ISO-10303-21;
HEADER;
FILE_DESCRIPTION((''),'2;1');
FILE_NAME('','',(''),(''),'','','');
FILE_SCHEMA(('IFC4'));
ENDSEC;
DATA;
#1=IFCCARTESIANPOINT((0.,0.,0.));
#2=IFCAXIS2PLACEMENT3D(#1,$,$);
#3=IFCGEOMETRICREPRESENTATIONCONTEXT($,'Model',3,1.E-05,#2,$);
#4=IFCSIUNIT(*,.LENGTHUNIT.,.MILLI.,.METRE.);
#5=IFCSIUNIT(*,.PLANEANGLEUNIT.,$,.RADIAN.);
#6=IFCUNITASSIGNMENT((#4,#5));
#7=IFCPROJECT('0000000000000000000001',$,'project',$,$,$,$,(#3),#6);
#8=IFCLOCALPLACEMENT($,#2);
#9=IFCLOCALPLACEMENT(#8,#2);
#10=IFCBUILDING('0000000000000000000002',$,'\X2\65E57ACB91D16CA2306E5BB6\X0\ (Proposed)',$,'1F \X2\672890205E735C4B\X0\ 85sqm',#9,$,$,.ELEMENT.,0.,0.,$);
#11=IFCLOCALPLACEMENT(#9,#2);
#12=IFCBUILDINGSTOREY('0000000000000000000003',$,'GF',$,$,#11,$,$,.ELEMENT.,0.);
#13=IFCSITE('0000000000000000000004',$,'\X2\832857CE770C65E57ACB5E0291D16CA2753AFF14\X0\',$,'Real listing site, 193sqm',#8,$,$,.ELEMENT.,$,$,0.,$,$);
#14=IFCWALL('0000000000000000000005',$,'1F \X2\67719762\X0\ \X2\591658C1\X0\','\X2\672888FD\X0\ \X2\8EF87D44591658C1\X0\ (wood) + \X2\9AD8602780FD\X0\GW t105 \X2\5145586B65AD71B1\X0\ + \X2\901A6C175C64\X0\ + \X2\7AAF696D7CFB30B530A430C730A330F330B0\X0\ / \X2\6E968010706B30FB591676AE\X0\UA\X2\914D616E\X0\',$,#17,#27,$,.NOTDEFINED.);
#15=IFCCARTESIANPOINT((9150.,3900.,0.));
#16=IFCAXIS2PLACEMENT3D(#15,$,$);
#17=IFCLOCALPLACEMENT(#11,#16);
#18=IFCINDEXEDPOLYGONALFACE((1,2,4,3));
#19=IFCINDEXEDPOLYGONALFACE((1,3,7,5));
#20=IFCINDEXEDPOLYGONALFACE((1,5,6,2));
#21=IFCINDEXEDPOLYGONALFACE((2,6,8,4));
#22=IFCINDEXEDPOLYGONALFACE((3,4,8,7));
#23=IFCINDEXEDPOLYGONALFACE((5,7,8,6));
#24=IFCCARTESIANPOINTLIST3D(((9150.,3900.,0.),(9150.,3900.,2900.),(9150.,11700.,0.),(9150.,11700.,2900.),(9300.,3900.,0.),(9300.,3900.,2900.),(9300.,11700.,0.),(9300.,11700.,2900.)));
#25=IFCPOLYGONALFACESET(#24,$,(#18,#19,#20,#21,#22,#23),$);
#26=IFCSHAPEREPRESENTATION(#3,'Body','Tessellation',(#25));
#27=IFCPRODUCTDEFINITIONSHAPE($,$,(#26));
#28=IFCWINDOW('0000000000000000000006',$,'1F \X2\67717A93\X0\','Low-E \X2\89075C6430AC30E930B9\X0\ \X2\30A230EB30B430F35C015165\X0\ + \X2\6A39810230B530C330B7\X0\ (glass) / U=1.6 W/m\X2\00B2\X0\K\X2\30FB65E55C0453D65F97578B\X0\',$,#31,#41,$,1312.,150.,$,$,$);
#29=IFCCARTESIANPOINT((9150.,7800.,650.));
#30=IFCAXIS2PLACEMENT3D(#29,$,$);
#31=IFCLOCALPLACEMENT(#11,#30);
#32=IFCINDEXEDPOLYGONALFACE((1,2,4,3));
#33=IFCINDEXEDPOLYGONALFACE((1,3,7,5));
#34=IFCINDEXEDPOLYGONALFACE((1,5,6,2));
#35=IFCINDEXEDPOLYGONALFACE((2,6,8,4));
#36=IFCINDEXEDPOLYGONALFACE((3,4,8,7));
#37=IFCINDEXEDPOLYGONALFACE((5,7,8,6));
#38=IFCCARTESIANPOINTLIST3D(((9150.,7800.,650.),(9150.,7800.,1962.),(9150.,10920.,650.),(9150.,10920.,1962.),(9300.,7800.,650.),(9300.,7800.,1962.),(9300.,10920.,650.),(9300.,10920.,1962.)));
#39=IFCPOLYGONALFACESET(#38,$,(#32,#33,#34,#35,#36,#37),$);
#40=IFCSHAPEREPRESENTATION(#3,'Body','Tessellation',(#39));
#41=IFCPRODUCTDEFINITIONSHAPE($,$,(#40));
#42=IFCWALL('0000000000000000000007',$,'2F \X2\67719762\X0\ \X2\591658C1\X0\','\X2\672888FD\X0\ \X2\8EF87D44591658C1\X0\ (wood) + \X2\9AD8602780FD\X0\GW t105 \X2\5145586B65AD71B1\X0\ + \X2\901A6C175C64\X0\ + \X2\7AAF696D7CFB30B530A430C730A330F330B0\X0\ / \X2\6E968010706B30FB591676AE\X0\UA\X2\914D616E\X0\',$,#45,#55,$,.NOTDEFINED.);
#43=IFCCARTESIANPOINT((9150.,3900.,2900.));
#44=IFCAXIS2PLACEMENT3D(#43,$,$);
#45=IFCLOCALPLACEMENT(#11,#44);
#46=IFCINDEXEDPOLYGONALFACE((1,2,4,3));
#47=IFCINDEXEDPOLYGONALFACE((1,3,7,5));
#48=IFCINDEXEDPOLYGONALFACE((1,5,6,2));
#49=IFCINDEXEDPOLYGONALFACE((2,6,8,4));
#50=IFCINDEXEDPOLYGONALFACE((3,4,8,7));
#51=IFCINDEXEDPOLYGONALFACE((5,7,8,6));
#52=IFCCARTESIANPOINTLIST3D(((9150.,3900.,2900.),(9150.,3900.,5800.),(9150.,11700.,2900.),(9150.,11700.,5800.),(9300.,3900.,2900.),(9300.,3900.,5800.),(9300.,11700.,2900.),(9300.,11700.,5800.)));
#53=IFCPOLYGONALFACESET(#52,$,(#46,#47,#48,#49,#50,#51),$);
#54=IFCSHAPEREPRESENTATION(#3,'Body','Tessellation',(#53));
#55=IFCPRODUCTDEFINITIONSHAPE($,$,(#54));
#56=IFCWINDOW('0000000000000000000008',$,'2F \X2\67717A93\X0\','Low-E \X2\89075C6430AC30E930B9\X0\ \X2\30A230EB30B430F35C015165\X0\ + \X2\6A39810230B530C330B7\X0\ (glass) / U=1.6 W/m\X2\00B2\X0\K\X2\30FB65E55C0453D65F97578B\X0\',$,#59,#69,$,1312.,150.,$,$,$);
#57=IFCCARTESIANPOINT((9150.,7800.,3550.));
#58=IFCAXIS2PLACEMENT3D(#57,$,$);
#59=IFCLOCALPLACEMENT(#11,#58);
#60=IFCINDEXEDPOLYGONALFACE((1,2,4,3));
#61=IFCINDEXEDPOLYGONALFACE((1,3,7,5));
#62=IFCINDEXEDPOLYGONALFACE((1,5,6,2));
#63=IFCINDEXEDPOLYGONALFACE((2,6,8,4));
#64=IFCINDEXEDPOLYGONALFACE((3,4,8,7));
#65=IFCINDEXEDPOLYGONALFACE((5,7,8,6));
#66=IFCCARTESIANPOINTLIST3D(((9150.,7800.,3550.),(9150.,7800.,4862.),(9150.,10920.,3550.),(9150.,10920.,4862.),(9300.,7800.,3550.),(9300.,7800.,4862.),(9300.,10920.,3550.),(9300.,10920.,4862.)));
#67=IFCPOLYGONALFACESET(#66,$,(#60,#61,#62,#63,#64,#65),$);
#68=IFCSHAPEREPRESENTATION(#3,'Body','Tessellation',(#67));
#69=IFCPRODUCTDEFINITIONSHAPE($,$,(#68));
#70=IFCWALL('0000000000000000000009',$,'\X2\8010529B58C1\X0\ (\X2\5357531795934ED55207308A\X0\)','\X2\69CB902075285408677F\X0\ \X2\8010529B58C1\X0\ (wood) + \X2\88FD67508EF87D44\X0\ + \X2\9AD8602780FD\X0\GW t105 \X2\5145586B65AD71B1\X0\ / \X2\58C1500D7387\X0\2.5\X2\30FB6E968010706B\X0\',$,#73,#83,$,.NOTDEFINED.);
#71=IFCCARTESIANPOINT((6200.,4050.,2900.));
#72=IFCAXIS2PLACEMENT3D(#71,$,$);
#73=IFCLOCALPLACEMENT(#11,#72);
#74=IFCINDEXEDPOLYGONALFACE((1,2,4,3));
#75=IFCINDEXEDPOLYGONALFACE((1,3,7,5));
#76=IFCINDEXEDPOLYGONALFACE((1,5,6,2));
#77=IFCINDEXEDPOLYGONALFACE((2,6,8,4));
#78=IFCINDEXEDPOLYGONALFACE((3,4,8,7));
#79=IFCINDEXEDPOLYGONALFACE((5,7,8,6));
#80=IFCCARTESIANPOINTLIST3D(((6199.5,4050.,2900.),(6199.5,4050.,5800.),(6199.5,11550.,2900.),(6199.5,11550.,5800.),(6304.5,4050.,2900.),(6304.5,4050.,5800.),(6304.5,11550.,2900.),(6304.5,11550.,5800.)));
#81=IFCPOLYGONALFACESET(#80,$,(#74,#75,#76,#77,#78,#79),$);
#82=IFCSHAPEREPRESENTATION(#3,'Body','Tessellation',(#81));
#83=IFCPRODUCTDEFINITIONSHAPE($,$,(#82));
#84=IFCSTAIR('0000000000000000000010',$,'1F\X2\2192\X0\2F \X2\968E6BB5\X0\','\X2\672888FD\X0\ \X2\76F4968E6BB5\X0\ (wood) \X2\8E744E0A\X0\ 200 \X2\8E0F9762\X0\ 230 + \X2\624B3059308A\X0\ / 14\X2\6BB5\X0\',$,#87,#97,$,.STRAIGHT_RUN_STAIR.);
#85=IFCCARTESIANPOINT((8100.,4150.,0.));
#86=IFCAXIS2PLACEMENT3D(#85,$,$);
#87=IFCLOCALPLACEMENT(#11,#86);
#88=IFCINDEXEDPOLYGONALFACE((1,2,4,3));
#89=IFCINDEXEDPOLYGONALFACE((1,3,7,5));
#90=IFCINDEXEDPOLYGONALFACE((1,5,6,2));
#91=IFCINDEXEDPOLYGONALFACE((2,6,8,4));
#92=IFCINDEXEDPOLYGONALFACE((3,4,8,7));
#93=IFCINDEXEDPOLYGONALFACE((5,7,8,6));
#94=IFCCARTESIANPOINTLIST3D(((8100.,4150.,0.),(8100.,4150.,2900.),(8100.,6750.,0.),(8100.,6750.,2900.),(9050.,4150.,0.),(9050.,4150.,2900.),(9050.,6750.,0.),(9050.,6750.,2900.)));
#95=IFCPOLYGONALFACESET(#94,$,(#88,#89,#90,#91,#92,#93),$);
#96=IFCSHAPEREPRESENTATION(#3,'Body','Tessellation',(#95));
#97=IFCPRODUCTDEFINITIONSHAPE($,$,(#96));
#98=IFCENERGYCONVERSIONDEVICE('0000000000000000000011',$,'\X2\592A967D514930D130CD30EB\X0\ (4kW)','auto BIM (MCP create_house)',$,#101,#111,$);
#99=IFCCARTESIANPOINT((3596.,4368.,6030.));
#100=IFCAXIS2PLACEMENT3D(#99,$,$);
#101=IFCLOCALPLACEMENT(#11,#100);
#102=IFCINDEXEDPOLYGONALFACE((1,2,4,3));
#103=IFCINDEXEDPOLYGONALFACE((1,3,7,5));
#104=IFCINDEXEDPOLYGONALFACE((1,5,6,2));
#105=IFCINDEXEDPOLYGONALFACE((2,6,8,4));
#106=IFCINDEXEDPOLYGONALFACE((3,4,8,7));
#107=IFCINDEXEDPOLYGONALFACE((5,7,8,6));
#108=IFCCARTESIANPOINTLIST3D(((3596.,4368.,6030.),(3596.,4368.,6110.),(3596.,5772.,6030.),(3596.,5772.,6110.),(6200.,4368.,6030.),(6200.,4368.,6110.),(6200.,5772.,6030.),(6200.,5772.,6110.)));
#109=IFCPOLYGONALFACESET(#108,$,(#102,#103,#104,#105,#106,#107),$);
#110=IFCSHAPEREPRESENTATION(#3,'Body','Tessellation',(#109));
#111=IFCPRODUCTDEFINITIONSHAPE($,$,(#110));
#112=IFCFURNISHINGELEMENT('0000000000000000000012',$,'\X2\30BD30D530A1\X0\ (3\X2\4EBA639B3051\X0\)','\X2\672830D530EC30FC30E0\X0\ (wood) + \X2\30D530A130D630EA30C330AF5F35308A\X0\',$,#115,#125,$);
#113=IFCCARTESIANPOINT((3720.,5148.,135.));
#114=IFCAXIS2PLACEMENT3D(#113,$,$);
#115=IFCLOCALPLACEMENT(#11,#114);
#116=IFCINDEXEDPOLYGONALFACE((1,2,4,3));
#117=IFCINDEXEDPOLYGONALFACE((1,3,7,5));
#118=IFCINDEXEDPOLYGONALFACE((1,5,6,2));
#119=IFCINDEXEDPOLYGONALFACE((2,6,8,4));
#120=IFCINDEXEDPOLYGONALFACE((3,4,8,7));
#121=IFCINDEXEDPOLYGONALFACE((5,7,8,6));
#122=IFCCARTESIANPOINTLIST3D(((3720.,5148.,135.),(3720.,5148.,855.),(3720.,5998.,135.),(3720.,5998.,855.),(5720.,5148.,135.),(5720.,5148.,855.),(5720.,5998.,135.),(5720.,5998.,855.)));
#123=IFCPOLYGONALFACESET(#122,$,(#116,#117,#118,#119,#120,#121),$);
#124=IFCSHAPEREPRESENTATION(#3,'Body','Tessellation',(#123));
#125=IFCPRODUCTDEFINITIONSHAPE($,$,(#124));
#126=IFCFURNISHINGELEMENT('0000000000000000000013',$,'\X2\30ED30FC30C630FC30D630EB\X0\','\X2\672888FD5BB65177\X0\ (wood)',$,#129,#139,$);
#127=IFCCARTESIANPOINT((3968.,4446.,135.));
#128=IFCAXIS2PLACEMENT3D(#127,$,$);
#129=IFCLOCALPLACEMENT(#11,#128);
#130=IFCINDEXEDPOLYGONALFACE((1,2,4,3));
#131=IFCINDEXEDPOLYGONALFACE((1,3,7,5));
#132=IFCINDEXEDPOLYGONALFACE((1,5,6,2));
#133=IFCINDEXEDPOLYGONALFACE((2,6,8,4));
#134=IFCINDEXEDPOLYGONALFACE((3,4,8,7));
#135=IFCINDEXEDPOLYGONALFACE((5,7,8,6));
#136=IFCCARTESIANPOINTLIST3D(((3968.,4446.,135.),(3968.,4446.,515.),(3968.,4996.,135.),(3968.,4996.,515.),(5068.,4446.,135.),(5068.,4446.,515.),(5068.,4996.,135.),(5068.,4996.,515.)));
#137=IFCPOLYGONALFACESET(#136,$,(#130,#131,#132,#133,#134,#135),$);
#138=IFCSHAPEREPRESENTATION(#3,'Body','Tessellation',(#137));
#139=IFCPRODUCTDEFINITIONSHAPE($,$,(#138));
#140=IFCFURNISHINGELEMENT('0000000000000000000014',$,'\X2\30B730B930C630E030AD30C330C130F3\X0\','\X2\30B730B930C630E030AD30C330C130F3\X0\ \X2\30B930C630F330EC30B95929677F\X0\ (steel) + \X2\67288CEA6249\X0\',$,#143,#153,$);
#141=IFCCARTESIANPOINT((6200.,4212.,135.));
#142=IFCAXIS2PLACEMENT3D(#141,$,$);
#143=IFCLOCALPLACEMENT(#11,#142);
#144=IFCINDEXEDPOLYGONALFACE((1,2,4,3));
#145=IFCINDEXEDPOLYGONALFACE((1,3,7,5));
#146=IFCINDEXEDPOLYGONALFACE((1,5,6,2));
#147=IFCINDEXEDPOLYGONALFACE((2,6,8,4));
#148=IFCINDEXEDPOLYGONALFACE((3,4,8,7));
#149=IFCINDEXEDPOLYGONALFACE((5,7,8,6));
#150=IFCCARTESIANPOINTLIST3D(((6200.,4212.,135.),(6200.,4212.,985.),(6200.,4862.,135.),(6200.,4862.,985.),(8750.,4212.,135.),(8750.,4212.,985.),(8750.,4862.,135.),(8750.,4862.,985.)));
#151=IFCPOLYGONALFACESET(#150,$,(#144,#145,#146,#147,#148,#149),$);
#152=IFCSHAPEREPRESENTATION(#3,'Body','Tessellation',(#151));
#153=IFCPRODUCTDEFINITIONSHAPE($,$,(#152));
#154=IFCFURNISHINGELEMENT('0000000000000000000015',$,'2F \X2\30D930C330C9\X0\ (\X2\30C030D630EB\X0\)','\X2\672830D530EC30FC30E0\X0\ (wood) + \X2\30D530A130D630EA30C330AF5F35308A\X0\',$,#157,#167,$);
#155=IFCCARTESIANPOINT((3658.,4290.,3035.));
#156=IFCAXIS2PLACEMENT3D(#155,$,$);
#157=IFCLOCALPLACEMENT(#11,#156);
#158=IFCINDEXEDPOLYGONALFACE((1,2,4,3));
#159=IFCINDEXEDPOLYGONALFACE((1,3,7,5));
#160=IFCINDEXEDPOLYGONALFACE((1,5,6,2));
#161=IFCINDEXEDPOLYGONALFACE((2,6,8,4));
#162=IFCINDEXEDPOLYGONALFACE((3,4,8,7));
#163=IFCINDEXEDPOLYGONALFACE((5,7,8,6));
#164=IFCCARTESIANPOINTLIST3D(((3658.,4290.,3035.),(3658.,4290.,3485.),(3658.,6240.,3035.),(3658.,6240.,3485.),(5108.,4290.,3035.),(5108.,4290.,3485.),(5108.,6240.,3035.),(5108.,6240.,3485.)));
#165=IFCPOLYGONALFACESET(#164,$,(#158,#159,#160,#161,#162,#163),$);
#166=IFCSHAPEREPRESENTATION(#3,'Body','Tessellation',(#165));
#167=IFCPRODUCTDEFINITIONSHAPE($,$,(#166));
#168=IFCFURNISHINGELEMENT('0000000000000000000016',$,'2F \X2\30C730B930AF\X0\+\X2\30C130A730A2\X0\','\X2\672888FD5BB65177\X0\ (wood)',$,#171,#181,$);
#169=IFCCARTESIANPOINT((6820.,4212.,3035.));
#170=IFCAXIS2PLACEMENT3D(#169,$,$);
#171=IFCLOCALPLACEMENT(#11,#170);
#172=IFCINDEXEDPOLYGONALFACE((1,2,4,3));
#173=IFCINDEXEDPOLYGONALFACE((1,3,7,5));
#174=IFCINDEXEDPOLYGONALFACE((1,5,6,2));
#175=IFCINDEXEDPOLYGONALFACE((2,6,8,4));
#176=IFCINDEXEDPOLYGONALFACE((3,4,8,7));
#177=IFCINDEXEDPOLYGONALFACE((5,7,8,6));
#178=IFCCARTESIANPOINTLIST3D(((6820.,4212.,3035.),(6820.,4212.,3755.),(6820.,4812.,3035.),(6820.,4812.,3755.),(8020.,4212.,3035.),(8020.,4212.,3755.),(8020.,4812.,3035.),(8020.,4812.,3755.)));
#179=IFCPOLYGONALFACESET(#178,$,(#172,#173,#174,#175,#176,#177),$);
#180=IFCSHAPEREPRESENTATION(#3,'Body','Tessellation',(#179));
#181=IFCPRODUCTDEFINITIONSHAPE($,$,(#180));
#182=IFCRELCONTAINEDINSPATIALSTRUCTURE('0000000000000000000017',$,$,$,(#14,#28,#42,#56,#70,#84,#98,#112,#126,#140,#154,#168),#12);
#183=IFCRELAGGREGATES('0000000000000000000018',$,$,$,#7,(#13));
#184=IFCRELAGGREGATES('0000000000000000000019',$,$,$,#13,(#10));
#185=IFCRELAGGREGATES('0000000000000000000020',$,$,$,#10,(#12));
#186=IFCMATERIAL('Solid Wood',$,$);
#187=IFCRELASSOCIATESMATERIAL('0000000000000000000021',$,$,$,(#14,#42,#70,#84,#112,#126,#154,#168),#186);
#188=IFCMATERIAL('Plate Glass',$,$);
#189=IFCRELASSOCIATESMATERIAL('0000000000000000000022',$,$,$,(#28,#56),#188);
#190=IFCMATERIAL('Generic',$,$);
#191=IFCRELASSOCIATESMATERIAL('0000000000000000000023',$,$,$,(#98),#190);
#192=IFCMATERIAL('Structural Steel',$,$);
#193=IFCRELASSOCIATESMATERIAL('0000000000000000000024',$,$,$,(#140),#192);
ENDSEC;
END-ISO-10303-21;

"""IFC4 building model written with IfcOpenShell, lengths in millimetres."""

from ifc_helpers import new_model, si_unit, frame, frame_2d, origin, place, context, project, spatial, rectangle, extrude, material, element, fill, save


model = new_model("IFC4")

# Units and contexts
model_context = context("Model", 3, precision=1e-05, world=origin())
ifc_project = project(units=[si_unit("LENGTHUNIT", "METRE", prefix="MILLI"), si_unit("PLANEANGLEUNIT", "RADIAN")], contexts=[model_context])

# Site, building, storey
site_placement = place(None, origin())
site = spatial("IfcSite", under=ifc_project, at=site_placement, Name="茨城県日立市金沢町４", ObjectType="Real listing site, 193sqm", CompositionType="ELEMENT", RefElevation=0.0)
building_placement = place(site_placement, origin())
building = spatial("IfcBuilding", under=site, at=building_placement, Name="日立金沢の家 (Proposed)", ObjectType="1F 木造平屋 85sqm", CompositionType="ELEMENT", ElevationOfRefHeight=0.0, ElevationOfTerrain=0.0)
storey_placement = place(building_placement, origin())
storey = spatial("IfcBuildingStorey", under=building, at=storey_placement, Name="GF", CompositionType="ELEMENT", Elevation=0.0)

# Wall, opening, window
ifc_material_1 = material(Name="Solid Wood")
wall_1_placement = place(storey_placement, frame((9150.0, 3900.0, 0.0)))
wall_1 = element("IfcWall", 1, at=wall_1_placement, inside=storey, material=ifc_material_1, Name="1F 東面 外壁", Description="木製 軸組外壁 (wood) + 高性能GW t105 充填断熱 + 通気層 + 窯業系サイディング / 準耐火・外皮UA配慮", PredefinedType="NOTDEFINED", context=model_context, shape_type="SweptSolid", body=[
    extrude(rectangle(XDim=150.0, YDim=7800.0, at=frame_2d((75.0, 3900.0))), frame((9150.0, 3900.0, 0.0)), (0.0, 0.0, 1.0), 2900.0),
])
opening_1_placement = place(storey_placement, frame((9150.0, 7800.0, 650.0)))
opening_1 = element("IfcOpeningElement", 2, at=opening_1_placement, cuts=wall_1, PredefinedType="NOTDEFINED", context=model_context, shape_type="SweptSolid", body=[
    extrude(rectangle(XDim=150.0, YDim=3120.0, at=frame_2d((75.0, 1560.0))), frame((9150.0, 7800.0, 650.0)), (0.0, 0.0, 1.0), 1312.0),
])
ifc_material_2 = material(Name="Plate Glass")
window_1_placement = place(storey_placement, frame((9150.0, 7800.0, 650.0)))
window_1 = element("IfcWindow", 3, at=window_1_placement, inside=storey, material=ifc_material_2, Name="1F 東窓", Description="Low-E 複層ガラス アルゴン封入 + 樹脂サッシ (glass) / U=1.6 W/m²K・日射取得型", OverallHeight=1312.0, OverallWidth=150.0, context=model_context, shape_type="SweptSolid", body=[
    extrude(rectangle(XDim=150.0, YDim=3120.0, at=frame_2d((75.0, 1560.0))), frame((9150.0, 7800.0, 650.0)), (0.0, 0.0, 1.0), 1312.0),
])
fill(opening_1, window_1)

# Wall, opening, window
wall_2_placement = place(storey_placement, frame((9150.0, 3900.0, 2900.0)))
wall_2 = element("IfcWall", 4, at=wall_2_placement, inside=storey, material=ifc_material_1, Name="2F 東面 外壁", Description="木製 軸組外壁 (wood) + 高性能GW t105 充填断熱 + 通気層 + 窯業系サイディング / 準耐火・外皮UA配慮", PredefinedType="NOTDEFINED", context=model_context, shape_type="SweptSolid", body=[
    extrude(rectangle(XDim=150.0, YDim=7800.0, at=frame_2d((75.0, 3900.0))), frame((9150.0, 3900.0, 2900.0)), (0.0, 0.0, 1.0), 2900.0),
])
opening_2_placement = place(storey_placement, frame((9150.0, 7800.0, 3550.0)))
opening_2 = element("IfcOpeningElement", 5, at=opening_2_placement, cuts=wall_2, PredefinedType="NOTDEFINED", context=model_context, shape_type="SweptSolid", body=[
    extrude(rectangle(XDim=150.0, YDim=3120.0, at=frame_2d((75.0, 1560.0))), frame((9150.0, 7800.0, 3550.0)), (0.0, 0.0, 1.0), 1312.0),
])
window_2_placement = place(storey_placement, frame((9150.0, 7800.0, 3550.0)))
window_2 = element("IfcWindow", 6, at=window_2_placement, inside=storey, material=ifc_material_2, Name="2F 東窓", Description="Low-E 複層ガラス アルゴン封入 + 樹脂サッシ (glass) / U=1.6 W/m²K・日射取得型", OverallHeight=1312.0, OverallWidth=150.0, context=model_context, shape_type="SweptSolid", body=[
    extrude(rectangle(XDim=150.0, YDim=3120.0, at=frame_2d((75.0, 1560.0))), frame((9150.0, 7800.0, 3550.0)), (0.0, 0.0, 1.0), 1312.0),
])
fill(opening_2, window_2)

# Wall
wall_3_placement = place(storey_placement, frame((6200.0, 4050.0, 2900.0)))
element("IfcWall", 7, at=wall_3_placement, inside=storey, material=ifc_material_1, Name="耐力壁 (南北間仕切り)", Description="構造用合板 耐力壁 (wood) + 製材軸組 + 高性能GW t105 充填断熱 / 壁倍率2.5・準耐火", PredefinedType="NOTDEFINED", context=model_context, shape_type="SweptSolid", body=[
    extrude(rectangle(XDim=105.0, YDim=7500.0, at=frame_2d((52.0, 3750.0))), frame((6200.0, 4050.0, 2900.0)), (0.0, 0.0, 1.0), 2900.0),
])

# Stair
stair_placement = place(storey_placement, frame((8100.0, 4150.0, 0.0)))
element("IfcStair", 8, at=stair_placement, inside=storey, material=ifc_material_1, Name="1F→2F 階段", Description="木製 直階段 (wood) 蹴上 200 踏面 230 + 手すり / 14段", PredefinedType="STRAIGHT_RUN_STAIR", context=model_context, shape_type="SweptSolid", body=[
    extrude(rectangle(XDim=950.0, YDim=2600.0, at=frame_2d((475.0, 1300.0))), frame((8100.0, 4150.0, 0.0)), (0.0, 0.0, 1.0), 2900.0),
])

# Energy conversion device
ifc_material_3 = material(Name="Generic")
energy_conversion_device_placement = place(storey_placement, frame((3596.0, 4368.0, 6030.0)))
element("IfcEnergyConversionDevice", 9, at=energy_conversion_device_placement, inside=storey, material=ifc_material_3, Name="太陽光パネル (4kW)", Description="auto BIM (MCP create_house)", context=model_context, shape_type="SweptSolid", body=[
    extrude(rectangle(XDim=2604.0, YDim=1404.0, at=frame_2d((1302.0, 702.0))), frame((3596.0, 4368.0, 6030.0)), (0.0, 0.0, 1.0), 80.0),
])

# Furnishing elements
furnishing_1_placement = place(storey_placement, frame((3720.0, 5148.0, 135.0)))
element("IfcFurnishingElement", 10, at=furnishing_1_placement, inside=storey, material=ifc_material_1, Name="ソファ (3人掛け)", Description="木フレーム (wood) + ファブリック張り", context=model_context, shape_type="SweptSolid", body=[
    extrude(rectangle(XDim=2000.0, YDim=850.0, at=frame_2d((1000.0, 425.0))), frame((3720.0, 5148.0, 135.0)), (0.0, 0.0, 1.0), 720.0),
])
furnishing_2_placement = place(storey_placement, frame((3968.0, 4446.0, 135.0)))
element("IfcFurnishingElement", 11, at=furnishing_2_placement, inside=storey, material=ifc_material_1, Name="ローテーブル", Description="木製家具 (wood)", context=model_context, shape_type="SweptSolid", body=[
    extrude(rectangle(XDim=1100.0, YDim=550.0, at=frame_2d((550.0, 275.0))), frame((3968.0, 4446.0, 135.0)), (0.0, 0.0, 1.0), 380.0),
])
ifc_material_4 = material(Name="Structural Steel")
furnishing_3_placement = place(storey_placement, frame((6200.0, 4212.0, 135.0)))
element("IfcFurnishingElement", 12, at=furnishing_3_placement, inside=storey, material=ifc_material_4, Name="システムキッチン", Description="システムキッチン ステンレス天板 (steel) + 木質扉", context=model_context, shape_type="SweptSolid", body=[
    extrude(rectangle(XDim=2550.0, YDim=650.0, at=frame_2d((1275.0, 325.0))), frame((6200.0, 4212.0, 135.0)), (0.0, 0.0, 1.0), 850.0),
])
furnishing_4_placement = place(storey_placement, frame((3658.0, 4290.0, 3035.0)))
element("IfcFurnishingElement", 13, at=furnishing_4_placement, inside=storey, material=ifc_material_1, Name="2F ベッド (ダブル)", Description="木フレーム (wood) + ファブリック張り", context=model_context, shape_type="SweptSolid", body=[
    extrude(rectangle(XDim=1450.0, YDim=1950.0, at=frame_2d((725.0, 975.0))), frame((3658.0, 4290.0, 3035.0)), (0.0, 0.0, 1.0), 450.0),
])
furnishing_5_placement = place(storey_placement, frame((6820.0, 4212.0, 3035.0)))
element("IfcFurnishingElement", 14, at=furnishing_5_placement, inside=storey, material=ifc_material_1, Name="2F デスク+チェア", Description="木製家具 (wood)", context=model_context, shape_type="SweptSolid", body=[
    extrude(rectangle(XDim=1200.0, YDim=600.0, at=frame_2d((600.0, 300.0))), frame((6820.0, 4212.0, 3035.0)), (0.0, 0.0, 1.0), 720.0),
])

save(model, "model.ifc")
